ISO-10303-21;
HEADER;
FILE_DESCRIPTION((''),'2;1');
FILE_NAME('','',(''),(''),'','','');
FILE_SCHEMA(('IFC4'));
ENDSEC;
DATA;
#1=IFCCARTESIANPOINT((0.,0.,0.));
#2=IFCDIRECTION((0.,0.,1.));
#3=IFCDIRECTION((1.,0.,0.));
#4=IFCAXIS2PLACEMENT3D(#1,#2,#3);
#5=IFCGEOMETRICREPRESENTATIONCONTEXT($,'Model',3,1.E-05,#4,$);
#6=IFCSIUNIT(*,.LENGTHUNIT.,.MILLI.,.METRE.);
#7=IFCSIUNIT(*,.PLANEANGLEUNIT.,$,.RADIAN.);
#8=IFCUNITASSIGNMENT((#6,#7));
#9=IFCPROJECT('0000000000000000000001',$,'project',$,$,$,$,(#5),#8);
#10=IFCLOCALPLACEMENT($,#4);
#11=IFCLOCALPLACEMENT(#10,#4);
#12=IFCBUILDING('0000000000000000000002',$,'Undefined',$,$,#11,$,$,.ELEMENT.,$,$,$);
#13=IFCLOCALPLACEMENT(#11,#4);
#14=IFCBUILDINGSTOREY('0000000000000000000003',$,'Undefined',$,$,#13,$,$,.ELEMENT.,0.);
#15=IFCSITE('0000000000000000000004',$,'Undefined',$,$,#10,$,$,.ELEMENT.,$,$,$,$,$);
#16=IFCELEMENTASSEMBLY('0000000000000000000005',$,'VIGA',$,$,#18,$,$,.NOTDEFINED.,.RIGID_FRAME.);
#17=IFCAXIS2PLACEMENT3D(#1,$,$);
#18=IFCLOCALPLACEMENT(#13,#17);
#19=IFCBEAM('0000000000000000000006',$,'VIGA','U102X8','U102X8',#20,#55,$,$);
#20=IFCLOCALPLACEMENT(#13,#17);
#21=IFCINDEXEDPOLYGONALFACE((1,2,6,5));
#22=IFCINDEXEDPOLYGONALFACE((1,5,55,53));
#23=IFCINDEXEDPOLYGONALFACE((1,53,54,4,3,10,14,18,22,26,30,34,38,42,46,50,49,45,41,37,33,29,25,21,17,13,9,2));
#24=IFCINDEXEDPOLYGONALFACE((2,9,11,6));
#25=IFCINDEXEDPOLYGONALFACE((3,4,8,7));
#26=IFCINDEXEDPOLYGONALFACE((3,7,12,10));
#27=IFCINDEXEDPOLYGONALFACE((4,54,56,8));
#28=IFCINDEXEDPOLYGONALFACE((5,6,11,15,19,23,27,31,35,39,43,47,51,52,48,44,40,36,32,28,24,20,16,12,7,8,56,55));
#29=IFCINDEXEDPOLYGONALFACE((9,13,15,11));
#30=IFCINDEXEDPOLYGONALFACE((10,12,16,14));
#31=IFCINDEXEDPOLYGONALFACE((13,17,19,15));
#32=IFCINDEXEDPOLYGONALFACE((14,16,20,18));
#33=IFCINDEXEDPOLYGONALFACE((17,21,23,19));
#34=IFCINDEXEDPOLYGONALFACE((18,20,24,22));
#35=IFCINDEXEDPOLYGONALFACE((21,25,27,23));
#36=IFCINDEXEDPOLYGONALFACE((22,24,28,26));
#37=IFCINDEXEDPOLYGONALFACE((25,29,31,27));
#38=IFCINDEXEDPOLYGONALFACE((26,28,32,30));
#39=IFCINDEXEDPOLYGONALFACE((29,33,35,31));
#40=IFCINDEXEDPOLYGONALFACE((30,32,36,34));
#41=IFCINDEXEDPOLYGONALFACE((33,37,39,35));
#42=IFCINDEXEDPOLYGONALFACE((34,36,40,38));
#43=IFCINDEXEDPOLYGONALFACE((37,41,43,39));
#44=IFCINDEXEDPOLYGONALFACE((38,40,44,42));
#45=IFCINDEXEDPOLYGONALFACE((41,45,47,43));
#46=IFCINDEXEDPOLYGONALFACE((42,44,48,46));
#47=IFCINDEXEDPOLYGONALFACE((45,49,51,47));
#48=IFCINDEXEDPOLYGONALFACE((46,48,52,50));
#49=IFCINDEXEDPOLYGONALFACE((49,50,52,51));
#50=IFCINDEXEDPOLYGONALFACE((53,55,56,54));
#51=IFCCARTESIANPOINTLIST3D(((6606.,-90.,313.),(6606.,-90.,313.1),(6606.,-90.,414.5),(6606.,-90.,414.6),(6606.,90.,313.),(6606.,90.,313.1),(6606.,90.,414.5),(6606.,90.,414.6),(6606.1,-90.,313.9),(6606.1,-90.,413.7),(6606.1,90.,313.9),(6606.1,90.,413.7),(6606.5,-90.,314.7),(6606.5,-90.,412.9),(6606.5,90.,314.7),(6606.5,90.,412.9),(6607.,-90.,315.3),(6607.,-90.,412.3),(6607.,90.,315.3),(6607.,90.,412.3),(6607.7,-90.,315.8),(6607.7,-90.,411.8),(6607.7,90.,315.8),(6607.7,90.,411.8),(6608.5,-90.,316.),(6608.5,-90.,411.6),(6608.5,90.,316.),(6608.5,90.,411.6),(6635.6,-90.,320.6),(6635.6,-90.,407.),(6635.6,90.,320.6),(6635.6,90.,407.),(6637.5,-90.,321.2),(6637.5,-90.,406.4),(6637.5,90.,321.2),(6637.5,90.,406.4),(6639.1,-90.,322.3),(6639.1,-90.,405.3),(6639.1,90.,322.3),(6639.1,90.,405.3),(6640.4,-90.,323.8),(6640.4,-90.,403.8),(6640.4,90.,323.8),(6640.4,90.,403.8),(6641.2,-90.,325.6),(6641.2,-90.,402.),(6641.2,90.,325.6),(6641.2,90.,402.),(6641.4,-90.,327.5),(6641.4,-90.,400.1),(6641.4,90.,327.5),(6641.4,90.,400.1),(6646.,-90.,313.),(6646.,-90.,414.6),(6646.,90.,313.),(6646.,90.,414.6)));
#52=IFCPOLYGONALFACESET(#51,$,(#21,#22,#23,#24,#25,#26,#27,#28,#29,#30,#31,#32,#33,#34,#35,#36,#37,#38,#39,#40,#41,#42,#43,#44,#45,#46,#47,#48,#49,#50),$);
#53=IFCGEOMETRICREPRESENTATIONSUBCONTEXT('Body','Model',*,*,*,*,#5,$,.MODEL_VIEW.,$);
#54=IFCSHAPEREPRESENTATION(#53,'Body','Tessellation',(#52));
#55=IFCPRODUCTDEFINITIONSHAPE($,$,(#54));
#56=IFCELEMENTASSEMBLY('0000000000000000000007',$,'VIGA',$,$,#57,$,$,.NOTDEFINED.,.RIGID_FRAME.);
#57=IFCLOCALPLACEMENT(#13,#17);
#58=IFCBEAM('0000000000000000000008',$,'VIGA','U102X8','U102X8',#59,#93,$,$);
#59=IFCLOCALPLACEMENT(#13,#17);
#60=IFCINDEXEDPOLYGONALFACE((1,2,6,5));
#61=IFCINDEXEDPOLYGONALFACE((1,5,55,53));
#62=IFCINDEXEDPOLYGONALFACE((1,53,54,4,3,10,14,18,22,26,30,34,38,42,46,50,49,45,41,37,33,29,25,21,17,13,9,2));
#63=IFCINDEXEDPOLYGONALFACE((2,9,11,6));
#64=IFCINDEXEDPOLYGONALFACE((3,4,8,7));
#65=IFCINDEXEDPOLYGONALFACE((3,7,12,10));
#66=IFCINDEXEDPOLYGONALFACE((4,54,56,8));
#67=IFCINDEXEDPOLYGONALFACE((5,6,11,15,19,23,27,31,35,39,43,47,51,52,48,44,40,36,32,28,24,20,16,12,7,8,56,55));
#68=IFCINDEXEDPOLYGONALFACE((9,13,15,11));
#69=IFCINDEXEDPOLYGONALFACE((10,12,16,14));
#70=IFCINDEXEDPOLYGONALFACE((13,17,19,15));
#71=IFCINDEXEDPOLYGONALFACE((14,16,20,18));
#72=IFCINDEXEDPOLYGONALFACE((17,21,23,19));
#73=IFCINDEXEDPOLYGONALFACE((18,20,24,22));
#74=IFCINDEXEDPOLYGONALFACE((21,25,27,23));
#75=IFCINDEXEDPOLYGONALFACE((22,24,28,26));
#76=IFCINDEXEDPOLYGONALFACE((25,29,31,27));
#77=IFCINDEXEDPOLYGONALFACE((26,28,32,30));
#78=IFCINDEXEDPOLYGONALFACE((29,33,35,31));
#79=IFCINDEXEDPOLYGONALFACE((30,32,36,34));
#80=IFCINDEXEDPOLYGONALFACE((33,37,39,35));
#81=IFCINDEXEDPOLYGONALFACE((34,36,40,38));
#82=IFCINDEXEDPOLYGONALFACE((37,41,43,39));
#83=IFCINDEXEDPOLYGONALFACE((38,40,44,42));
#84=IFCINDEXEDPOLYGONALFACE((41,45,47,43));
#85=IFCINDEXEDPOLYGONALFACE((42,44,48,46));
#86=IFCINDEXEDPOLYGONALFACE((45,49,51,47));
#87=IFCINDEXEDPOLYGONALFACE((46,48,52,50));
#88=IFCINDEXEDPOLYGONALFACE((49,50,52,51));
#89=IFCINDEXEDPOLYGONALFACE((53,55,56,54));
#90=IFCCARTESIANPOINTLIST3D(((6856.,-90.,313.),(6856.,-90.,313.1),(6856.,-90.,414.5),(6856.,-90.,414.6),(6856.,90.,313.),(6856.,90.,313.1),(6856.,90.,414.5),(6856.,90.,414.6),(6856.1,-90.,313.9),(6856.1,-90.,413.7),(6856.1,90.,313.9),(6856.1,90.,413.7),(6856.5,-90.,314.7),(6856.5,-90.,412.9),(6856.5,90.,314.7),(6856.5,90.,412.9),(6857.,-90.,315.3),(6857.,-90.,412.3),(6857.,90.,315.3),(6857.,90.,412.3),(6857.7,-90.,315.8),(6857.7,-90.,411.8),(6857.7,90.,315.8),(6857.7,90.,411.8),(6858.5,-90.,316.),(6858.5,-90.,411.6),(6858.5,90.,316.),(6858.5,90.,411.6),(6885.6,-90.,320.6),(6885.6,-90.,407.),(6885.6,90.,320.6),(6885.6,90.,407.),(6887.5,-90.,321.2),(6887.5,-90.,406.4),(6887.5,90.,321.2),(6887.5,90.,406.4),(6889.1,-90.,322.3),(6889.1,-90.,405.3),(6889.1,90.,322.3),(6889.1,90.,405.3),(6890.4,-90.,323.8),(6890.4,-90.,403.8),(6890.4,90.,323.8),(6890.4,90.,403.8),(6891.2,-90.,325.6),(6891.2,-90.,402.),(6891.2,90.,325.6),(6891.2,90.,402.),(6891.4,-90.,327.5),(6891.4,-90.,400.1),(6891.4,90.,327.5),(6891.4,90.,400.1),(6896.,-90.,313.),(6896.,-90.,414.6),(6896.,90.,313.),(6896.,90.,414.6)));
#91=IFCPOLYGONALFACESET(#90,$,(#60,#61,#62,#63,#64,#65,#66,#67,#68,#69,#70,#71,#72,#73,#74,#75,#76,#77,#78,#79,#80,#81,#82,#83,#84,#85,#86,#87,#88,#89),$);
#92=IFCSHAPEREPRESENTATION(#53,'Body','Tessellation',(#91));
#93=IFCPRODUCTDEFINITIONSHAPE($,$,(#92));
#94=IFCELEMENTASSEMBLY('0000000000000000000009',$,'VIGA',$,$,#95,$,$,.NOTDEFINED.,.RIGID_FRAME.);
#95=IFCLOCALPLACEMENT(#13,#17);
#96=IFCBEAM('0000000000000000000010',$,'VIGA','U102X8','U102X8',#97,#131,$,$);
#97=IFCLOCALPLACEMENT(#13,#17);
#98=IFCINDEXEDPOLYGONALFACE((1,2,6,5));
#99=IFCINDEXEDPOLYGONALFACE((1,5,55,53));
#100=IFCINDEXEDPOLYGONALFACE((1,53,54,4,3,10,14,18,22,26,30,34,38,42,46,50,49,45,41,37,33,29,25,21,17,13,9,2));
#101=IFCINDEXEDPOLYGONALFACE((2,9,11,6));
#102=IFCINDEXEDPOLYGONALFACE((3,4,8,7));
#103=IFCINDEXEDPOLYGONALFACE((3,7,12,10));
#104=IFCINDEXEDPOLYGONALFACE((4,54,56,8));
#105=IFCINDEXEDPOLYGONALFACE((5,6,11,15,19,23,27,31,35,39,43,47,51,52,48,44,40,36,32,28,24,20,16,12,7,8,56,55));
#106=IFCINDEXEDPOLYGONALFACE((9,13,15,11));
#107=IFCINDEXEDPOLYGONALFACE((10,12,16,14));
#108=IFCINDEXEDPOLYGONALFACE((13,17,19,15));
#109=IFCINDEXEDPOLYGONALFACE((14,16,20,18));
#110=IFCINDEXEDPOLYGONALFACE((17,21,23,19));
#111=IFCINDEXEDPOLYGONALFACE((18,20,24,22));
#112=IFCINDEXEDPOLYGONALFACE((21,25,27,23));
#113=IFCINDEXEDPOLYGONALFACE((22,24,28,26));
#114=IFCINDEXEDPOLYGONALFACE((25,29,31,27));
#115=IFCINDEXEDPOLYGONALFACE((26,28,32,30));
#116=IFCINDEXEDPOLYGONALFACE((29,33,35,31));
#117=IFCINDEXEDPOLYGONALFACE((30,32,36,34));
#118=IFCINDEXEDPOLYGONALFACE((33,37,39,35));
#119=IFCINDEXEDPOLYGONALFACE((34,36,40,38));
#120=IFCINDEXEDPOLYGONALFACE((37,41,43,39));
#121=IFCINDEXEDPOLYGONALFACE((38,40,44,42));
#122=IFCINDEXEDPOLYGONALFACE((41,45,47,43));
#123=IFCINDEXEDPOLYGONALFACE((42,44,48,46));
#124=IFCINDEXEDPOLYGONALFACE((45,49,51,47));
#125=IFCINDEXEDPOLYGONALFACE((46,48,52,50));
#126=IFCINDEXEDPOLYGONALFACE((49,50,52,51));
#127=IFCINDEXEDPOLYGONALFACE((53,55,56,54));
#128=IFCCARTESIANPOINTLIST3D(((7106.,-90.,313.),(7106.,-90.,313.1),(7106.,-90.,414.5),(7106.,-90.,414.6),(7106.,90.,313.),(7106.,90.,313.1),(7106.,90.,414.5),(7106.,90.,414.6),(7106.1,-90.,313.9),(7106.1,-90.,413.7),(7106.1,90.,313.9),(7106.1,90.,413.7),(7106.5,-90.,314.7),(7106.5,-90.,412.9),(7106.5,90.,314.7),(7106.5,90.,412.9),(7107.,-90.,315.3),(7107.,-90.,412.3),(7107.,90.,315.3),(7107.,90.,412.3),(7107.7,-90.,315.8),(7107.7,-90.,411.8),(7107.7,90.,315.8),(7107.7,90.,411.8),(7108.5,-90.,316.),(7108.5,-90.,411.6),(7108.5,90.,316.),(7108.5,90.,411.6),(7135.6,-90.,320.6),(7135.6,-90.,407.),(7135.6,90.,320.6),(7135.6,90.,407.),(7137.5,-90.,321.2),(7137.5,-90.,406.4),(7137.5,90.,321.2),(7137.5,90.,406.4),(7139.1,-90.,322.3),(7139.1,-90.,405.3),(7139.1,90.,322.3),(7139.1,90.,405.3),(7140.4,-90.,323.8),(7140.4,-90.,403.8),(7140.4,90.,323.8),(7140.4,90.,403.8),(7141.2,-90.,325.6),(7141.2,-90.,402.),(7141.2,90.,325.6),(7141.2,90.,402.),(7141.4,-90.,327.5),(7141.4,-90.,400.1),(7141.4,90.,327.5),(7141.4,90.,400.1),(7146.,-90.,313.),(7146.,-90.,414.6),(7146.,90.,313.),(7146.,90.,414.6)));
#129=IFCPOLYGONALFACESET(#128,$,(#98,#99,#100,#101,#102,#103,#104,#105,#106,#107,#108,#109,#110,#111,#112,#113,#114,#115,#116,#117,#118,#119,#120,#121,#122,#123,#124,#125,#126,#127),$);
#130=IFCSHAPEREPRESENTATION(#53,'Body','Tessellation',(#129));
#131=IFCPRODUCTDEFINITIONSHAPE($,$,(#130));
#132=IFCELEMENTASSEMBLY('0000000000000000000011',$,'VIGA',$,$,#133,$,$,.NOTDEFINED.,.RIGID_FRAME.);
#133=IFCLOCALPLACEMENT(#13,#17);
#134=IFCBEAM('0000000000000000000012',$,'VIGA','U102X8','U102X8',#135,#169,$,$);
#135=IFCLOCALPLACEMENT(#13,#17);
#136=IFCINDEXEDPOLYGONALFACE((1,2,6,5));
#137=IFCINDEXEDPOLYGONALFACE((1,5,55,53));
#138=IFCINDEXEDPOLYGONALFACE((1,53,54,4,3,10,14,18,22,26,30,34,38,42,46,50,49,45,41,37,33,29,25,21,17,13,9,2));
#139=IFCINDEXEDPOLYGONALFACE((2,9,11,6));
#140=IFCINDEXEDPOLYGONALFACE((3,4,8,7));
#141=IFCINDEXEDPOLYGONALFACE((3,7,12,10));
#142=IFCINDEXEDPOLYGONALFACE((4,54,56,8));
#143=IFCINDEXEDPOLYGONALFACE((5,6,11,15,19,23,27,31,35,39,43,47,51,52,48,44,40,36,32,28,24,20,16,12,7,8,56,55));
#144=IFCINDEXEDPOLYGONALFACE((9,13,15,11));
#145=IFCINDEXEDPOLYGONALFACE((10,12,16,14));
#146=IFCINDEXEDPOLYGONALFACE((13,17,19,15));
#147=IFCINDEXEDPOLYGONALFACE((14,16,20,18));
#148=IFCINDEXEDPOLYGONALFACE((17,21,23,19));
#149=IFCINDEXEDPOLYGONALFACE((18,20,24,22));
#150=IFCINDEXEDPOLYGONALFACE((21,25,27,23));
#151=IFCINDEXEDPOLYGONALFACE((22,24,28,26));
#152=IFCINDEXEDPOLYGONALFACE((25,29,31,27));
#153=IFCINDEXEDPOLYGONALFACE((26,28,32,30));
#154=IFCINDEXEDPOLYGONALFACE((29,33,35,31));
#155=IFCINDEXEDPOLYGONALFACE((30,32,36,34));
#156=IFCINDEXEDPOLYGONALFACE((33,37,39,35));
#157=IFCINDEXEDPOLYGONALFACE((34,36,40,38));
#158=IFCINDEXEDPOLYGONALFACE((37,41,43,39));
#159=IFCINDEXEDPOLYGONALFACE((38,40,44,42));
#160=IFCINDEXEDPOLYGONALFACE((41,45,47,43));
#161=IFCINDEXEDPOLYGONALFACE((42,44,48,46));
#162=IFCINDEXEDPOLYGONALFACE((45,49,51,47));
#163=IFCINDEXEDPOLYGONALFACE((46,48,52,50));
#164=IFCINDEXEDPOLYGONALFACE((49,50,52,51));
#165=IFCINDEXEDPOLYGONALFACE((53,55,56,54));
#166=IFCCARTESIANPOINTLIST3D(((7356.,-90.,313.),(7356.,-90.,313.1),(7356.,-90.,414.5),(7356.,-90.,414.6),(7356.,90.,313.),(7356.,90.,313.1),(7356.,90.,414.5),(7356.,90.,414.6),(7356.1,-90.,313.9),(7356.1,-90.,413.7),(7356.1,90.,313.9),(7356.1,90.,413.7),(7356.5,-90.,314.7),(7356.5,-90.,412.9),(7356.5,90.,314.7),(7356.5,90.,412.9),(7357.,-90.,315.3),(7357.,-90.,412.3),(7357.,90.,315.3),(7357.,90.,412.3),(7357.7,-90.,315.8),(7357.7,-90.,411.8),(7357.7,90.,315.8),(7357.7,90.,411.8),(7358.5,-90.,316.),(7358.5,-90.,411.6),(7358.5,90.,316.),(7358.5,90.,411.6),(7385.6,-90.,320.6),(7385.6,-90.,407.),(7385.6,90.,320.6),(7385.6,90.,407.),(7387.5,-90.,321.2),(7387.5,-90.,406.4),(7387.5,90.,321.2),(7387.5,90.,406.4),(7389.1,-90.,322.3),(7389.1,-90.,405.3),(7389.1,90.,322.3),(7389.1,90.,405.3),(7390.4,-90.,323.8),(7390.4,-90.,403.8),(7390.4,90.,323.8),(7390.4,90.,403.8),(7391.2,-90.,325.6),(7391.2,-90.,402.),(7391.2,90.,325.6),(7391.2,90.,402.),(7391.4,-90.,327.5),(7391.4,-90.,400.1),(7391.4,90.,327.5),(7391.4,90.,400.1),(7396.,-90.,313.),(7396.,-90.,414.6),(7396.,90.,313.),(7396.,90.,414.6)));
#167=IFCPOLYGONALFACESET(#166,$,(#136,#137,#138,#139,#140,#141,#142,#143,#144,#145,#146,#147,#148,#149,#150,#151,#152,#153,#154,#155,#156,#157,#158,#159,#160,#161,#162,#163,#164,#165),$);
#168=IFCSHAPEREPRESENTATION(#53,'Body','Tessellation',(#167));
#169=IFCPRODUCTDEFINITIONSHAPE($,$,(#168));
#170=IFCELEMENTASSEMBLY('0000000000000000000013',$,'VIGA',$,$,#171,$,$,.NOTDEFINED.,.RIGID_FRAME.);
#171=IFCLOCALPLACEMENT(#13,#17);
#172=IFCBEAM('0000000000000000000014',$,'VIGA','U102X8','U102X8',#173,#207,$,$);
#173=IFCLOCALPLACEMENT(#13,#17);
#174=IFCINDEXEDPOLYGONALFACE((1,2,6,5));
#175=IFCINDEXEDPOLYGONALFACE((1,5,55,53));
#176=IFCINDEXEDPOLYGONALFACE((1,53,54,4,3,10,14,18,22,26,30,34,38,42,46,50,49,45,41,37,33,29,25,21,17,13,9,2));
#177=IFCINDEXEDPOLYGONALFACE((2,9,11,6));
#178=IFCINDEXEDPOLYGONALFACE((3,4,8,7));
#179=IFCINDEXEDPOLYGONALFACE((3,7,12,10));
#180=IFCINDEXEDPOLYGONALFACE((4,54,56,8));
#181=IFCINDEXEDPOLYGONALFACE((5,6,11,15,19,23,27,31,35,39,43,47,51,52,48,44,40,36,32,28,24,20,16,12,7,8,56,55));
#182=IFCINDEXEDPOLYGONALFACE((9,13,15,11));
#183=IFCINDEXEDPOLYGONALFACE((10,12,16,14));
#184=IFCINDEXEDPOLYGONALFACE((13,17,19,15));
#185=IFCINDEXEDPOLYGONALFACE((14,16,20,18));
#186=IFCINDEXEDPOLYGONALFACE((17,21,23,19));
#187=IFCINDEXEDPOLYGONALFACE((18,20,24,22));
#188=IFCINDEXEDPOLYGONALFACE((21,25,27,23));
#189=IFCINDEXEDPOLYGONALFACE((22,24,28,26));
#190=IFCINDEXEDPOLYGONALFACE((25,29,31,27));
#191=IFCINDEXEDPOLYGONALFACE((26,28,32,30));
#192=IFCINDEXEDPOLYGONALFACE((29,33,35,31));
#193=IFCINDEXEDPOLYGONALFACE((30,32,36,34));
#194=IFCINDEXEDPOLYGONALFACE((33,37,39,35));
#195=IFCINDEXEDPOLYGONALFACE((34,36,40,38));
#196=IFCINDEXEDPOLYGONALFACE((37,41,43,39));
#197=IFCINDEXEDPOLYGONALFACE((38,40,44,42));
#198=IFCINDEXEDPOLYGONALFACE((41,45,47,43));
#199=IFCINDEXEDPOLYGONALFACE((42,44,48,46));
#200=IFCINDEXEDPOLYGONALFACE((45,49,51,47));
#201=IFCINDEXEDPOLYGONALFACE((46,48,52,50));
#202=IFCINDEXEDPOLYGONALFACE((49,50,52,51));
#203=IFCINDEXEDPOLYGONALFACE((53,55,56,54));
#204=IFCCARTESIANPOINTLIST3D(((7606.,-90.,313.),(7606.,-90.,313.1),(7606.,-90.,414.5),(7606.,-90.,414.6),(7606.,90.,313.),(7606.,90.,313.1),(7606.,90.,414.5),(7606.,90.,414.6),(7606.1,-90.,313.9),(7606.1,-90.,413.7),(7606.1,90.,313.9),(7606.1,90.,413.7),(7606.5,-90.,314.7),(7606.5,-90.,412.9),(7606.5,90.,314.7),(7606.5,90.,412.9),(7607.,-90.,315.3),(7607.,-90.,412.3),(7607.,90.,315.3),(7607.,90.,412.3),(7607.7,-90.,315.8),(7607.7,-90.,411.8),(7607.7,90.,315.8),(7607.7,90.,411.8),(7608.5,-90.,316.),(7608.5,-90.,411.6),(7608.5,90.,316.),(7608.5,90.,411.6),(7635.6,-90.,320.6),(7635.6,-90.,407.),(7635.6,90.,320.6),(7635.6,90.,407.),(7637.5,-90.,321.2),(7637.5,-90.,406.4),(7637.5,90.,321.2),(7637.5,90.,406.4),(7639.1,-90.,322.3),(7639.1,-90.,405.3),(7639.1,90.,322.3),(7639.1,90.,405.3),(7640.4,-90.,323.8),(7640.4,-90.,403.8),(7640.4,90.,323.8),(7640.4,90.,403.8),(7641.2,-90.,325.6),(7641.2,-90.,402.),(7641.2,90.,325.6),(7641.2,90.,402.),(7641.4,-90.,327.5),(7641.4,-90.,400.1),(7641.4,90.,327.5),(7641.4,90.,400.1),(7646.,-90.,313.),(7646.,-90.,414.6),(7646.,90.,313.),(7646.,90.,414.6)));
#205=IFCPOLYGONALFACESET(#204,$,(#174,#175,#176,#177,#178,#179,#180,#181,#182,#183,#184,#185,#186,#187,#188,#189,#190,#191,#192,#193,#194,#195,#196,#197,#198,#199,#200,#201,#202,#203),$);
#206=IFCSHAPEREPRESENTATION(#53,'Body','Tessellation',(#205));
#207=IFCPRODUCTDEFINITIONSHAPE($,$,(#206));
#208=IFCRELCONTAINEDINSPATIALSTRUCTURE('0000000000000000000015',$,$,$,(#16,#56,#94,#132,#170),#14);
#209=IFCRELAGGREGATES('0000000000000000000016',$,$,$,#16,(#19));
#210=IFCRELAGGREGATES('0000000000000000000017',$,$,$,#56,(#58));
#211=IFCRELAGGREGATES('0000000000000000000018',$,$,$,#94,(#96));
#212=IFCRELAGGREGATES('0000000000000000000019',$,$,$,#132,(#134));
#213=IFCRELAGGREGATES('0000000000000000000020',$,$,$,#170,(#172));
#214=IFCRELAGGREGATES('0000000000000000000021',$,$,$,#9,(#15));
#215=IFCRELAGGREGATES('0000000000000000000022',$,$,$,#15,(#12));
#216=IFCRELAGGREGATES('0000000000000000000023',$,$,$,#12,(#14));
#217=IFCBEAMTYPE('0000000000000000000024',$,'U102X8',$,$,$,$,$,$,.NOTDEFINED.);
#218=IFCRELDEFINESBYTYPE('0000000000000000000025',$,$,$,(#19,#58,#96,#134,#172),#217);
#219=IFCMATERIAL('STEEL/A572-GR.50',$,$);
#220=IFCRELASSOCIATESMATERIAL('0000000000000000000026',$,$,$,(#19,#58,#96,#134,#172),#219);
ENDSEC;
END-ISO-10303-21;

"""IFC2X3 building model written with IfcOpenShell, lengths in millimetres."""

from ifc_helpers import new_model, si_unit, frame, origin_with_axes, origin_2d_with_axis, place, context, subcontext, project, spatial, u_section, extrude, material, type_object, element, aggregate, save


model = new_model("IFC2X3")

# Units and contexts
model_context = context("Model", 3, precision=1e-05, world=origin_with_axes())
body_context = subcontext(model_context, "Body", "Model", "MODEL_VIEW")
ifc_project = project(units=[si_unit("LENGTHUNIT", "METRE", prefix="MILLI"), si_unit("PLANEANGLEUNIT", "RADIAN")], contexts=[model_context])

# Site, building, storey
site_placement = place(None, origin_with_axes())
site = spatial("IfcSite", under=ifc_project, at=site_placement, Name="Undefined", CompositionType="ELEMENT")
building_placement = place(site_placement, origin_with_axes())
building = spatial("IfcBuilding", under=site, at=building_placement, Name="Undefined", CompositionType="ELEMENT")
storey_placement = place(building_placement, origin_with_axes())
storey = spatial("IfcBuildingStorey", under=building, at=storey_placement, Name="Undefined", CompositionType="ELEMENT", Elevation=0.0)

# Element assemblies, beams
ifc_material_1 = material(Name="STEEL/A572-GR.50")
beam_type = type_object("IfcBeamType", Name="U102X8", PredefinedType="NOTDEFINED")
assembly_1_placement = place(storey_placement, origin_with_axes())
assembly_1 = element("IfcElementAssembly", 1, at=assembly_1_placement, inside=storey, Name="VIGA", AssemblyPlace="NOTDEFINED", PredefinedType="RIGID_FRAME")
beam_1_placement = place(assembly_1_placement, frame((6626.0, 90.0, 363.8), z_axis=(0.0, 0.0, 1.0), x_axis=(0.0, -1.0, 0.0)))
beam_1 = element("IfcBeam", 2, at=beam_1_placement, type_object=beam_type, material=ifc_material_1, Name="VIGA", Description="U102X8", ObjectType="U102X8", context=body_context, shape_type="SweptSolid", body=[
    extrude(u_section(Depth=101.6, FlangeWidth=40.0, WebThickness=4.6, FlangeThickness=6.0, FilletRadius=7.0, EdgeRadius=3.0, FlangeSlope=0.16839, at=origin_2d_with_axis()), frame((180.0, 0.0, 0.0), z_axis=(-1.0, 0.0, 0.0), x_axis=(0.0, -1.0, 0.0)), (0.0, 0.0, 1.0), 180.0),
])
aggregate(assembly_1, [beam_1])
assembly_2_placement = place(storey_placement, origin_with_axes())
assembly_2 = element("IfcElementAssembly", 3, at=assembly_2_placement, inside=storey, Name="VIGA", AssemblyPlace="NOTDEFINED", PredefinedType="RIGID_FRAME")
beam_2_placement = place(assembly_2_placement, frame((6876.0, 90.0, 363.8), z_axis=(0.0, 0.0, 1.0), x_axis=(0.0, -1.0, 0.0)))
beam_2 = element("IfcBeam", 4, at=beam_2_placement, type_object=beam_type, material=ifc_material_1, Name="VIGA", Description="U102X8", ObjectType="U102X8", context=body_context, shape_type="SweptSolid", body=[
    extrude(u_section(Depth=101.6, FlangeWidth=40.0, WebThickness=4.6, FlangeThickness=6.0, FilletRadius=7.0, EdgeRadius=3.0, FlangeSlope=0.16839, at=origin_2d_with_axis()), frame((180.0, 0.0, 0.0), z_axis=(-1.0, 0.0, 0.0), x_axis=(0.0, -1.0, 0.0)), (0.0, 0.0, 1.0), 180.0),
])
aggregate(assembly_2, [beam_2])
assembly_3_placement = place(storey_placement, origin_with_axes())
assembly_3 = element("IfcElementAssembly", 5, at=assembly_3_placement, inside=storey, Name="VIGA", AssemblyPlace="NOTDEFINED", PredefinedType="RIGID_FRAME")
beam_3_placement = place(assembly_3_placement, frame((7126.0, 90.0, 363.8), z_axis=(0.0, 0.0, 1.0), x_axis=(0.0, -1.0, 0.0)))
beam_3 = element("IfcBeam", 6, at=beam_3_placement, type_object=beam_type, material=ifc_material_1, Name="VIGA", Description="U102X8", ObjectType="U102X8", context=body_context, shape_type="SweptSolid", body=[
    extrude(u_section(Depth=101.6, FlangeWidth=40.0, WebThickness=4.6, FlangeThickness=6.0, FilletRadius=7.0, EdgeRadius=3.0, FlangeSlope=0.16839, at=origin_2d_with_axis()), frame((180.0, 0.0, 0.0), z_axis=(-1.0, 0.0, 0.0), x_axis=(0.0, -1.0, 0.0)), (0.0, 0.0, 1.0), 180.0),
])
aggregate(assembly_3, [beam_3])
assembly_4_placement = place(storey_placement, origin_with_axes())
assembly_4 = element("IfcElementAssembly", 7, at=assembly_4_placement, inside=storey, Name="VIGA", AssemblyPlace="NOTDEFINED", PredefinedType="RIGID_FRAME")
beam_4_placement = place(assembly_4_placement, frame((7376.0, 90.0, 363.8), z_axis=(0.0, 0.0, 1.0), x_axis=(0.0, -1.0, 0.0)))
beam_4 = element("IfcBeam", 8, at=beam_4_placement, type_object=beam_type, material=ifc_material_1, Name="VIGA", Description="U102X8", ObjectType="U102X8", context=body_context, shape_type="SweptSolid", body=[
    extrude(u_section(Depth=101.6, FlangeWidth=40.0, WebThickness=4.6, FlangeThickness=6.0, FilletRadius=7.0, EdgeRadius=3.0, FlangeSlope=0.16839, at=origin_2d_with_axis()), frame((180.0, 0.0, 0.0), z_axis=(-1.0, 0.0, 0.0), x_axis=(0.0, -1.0, 0.0)), (0.0, 0.0, 1.0), 180.0),
])
aggregate(assembly_4, [beam_4])
assembly_5_placement = place(storey_placement, origin_with_axes())
assembly_5 = element("IfcElementAssembly", 9, at=assembly_5_placement, inside=storey, Name="VIGA", AssemblyPlace="NOTDEFINED", PredefinedType="RIGID_FRAME")
beam_5_placement = place(assembly_5_placement, frame((7626.0, 90.0, 363.8), z_axis=(0.0, 0.0, 1.0), x_axis=(0.0, -1.0, 0.0)))
beam_5 = element("IfcBeam", 10, at=beam_5_placement, type_object=beam_type, material=ifc_material_1, Name="VIGA", Description="U102X8", ObjectType="U102X8", context=body_context, shape_type="SweptSolid", body=[
    extrude(u_section(Depth=101.6, FlangeWidth=40.0, WebThickness=4.6, FlangeThickness=6.0, FilletRadius=7.0, EdgeRadius=3.0, FlangeSlope=0.16839, at=origin_2d_with_axis()), frame((180.0, 0.0, 0.0), z_axis=(-1.0, 0.0, 0.0), x_axis=(0.0, -1.0, 0.0)), (0.0, 0.0, 1.0), 180.0),
])
aggregate(assembly_5, [beam_5])

save(model, "model.ifc")
